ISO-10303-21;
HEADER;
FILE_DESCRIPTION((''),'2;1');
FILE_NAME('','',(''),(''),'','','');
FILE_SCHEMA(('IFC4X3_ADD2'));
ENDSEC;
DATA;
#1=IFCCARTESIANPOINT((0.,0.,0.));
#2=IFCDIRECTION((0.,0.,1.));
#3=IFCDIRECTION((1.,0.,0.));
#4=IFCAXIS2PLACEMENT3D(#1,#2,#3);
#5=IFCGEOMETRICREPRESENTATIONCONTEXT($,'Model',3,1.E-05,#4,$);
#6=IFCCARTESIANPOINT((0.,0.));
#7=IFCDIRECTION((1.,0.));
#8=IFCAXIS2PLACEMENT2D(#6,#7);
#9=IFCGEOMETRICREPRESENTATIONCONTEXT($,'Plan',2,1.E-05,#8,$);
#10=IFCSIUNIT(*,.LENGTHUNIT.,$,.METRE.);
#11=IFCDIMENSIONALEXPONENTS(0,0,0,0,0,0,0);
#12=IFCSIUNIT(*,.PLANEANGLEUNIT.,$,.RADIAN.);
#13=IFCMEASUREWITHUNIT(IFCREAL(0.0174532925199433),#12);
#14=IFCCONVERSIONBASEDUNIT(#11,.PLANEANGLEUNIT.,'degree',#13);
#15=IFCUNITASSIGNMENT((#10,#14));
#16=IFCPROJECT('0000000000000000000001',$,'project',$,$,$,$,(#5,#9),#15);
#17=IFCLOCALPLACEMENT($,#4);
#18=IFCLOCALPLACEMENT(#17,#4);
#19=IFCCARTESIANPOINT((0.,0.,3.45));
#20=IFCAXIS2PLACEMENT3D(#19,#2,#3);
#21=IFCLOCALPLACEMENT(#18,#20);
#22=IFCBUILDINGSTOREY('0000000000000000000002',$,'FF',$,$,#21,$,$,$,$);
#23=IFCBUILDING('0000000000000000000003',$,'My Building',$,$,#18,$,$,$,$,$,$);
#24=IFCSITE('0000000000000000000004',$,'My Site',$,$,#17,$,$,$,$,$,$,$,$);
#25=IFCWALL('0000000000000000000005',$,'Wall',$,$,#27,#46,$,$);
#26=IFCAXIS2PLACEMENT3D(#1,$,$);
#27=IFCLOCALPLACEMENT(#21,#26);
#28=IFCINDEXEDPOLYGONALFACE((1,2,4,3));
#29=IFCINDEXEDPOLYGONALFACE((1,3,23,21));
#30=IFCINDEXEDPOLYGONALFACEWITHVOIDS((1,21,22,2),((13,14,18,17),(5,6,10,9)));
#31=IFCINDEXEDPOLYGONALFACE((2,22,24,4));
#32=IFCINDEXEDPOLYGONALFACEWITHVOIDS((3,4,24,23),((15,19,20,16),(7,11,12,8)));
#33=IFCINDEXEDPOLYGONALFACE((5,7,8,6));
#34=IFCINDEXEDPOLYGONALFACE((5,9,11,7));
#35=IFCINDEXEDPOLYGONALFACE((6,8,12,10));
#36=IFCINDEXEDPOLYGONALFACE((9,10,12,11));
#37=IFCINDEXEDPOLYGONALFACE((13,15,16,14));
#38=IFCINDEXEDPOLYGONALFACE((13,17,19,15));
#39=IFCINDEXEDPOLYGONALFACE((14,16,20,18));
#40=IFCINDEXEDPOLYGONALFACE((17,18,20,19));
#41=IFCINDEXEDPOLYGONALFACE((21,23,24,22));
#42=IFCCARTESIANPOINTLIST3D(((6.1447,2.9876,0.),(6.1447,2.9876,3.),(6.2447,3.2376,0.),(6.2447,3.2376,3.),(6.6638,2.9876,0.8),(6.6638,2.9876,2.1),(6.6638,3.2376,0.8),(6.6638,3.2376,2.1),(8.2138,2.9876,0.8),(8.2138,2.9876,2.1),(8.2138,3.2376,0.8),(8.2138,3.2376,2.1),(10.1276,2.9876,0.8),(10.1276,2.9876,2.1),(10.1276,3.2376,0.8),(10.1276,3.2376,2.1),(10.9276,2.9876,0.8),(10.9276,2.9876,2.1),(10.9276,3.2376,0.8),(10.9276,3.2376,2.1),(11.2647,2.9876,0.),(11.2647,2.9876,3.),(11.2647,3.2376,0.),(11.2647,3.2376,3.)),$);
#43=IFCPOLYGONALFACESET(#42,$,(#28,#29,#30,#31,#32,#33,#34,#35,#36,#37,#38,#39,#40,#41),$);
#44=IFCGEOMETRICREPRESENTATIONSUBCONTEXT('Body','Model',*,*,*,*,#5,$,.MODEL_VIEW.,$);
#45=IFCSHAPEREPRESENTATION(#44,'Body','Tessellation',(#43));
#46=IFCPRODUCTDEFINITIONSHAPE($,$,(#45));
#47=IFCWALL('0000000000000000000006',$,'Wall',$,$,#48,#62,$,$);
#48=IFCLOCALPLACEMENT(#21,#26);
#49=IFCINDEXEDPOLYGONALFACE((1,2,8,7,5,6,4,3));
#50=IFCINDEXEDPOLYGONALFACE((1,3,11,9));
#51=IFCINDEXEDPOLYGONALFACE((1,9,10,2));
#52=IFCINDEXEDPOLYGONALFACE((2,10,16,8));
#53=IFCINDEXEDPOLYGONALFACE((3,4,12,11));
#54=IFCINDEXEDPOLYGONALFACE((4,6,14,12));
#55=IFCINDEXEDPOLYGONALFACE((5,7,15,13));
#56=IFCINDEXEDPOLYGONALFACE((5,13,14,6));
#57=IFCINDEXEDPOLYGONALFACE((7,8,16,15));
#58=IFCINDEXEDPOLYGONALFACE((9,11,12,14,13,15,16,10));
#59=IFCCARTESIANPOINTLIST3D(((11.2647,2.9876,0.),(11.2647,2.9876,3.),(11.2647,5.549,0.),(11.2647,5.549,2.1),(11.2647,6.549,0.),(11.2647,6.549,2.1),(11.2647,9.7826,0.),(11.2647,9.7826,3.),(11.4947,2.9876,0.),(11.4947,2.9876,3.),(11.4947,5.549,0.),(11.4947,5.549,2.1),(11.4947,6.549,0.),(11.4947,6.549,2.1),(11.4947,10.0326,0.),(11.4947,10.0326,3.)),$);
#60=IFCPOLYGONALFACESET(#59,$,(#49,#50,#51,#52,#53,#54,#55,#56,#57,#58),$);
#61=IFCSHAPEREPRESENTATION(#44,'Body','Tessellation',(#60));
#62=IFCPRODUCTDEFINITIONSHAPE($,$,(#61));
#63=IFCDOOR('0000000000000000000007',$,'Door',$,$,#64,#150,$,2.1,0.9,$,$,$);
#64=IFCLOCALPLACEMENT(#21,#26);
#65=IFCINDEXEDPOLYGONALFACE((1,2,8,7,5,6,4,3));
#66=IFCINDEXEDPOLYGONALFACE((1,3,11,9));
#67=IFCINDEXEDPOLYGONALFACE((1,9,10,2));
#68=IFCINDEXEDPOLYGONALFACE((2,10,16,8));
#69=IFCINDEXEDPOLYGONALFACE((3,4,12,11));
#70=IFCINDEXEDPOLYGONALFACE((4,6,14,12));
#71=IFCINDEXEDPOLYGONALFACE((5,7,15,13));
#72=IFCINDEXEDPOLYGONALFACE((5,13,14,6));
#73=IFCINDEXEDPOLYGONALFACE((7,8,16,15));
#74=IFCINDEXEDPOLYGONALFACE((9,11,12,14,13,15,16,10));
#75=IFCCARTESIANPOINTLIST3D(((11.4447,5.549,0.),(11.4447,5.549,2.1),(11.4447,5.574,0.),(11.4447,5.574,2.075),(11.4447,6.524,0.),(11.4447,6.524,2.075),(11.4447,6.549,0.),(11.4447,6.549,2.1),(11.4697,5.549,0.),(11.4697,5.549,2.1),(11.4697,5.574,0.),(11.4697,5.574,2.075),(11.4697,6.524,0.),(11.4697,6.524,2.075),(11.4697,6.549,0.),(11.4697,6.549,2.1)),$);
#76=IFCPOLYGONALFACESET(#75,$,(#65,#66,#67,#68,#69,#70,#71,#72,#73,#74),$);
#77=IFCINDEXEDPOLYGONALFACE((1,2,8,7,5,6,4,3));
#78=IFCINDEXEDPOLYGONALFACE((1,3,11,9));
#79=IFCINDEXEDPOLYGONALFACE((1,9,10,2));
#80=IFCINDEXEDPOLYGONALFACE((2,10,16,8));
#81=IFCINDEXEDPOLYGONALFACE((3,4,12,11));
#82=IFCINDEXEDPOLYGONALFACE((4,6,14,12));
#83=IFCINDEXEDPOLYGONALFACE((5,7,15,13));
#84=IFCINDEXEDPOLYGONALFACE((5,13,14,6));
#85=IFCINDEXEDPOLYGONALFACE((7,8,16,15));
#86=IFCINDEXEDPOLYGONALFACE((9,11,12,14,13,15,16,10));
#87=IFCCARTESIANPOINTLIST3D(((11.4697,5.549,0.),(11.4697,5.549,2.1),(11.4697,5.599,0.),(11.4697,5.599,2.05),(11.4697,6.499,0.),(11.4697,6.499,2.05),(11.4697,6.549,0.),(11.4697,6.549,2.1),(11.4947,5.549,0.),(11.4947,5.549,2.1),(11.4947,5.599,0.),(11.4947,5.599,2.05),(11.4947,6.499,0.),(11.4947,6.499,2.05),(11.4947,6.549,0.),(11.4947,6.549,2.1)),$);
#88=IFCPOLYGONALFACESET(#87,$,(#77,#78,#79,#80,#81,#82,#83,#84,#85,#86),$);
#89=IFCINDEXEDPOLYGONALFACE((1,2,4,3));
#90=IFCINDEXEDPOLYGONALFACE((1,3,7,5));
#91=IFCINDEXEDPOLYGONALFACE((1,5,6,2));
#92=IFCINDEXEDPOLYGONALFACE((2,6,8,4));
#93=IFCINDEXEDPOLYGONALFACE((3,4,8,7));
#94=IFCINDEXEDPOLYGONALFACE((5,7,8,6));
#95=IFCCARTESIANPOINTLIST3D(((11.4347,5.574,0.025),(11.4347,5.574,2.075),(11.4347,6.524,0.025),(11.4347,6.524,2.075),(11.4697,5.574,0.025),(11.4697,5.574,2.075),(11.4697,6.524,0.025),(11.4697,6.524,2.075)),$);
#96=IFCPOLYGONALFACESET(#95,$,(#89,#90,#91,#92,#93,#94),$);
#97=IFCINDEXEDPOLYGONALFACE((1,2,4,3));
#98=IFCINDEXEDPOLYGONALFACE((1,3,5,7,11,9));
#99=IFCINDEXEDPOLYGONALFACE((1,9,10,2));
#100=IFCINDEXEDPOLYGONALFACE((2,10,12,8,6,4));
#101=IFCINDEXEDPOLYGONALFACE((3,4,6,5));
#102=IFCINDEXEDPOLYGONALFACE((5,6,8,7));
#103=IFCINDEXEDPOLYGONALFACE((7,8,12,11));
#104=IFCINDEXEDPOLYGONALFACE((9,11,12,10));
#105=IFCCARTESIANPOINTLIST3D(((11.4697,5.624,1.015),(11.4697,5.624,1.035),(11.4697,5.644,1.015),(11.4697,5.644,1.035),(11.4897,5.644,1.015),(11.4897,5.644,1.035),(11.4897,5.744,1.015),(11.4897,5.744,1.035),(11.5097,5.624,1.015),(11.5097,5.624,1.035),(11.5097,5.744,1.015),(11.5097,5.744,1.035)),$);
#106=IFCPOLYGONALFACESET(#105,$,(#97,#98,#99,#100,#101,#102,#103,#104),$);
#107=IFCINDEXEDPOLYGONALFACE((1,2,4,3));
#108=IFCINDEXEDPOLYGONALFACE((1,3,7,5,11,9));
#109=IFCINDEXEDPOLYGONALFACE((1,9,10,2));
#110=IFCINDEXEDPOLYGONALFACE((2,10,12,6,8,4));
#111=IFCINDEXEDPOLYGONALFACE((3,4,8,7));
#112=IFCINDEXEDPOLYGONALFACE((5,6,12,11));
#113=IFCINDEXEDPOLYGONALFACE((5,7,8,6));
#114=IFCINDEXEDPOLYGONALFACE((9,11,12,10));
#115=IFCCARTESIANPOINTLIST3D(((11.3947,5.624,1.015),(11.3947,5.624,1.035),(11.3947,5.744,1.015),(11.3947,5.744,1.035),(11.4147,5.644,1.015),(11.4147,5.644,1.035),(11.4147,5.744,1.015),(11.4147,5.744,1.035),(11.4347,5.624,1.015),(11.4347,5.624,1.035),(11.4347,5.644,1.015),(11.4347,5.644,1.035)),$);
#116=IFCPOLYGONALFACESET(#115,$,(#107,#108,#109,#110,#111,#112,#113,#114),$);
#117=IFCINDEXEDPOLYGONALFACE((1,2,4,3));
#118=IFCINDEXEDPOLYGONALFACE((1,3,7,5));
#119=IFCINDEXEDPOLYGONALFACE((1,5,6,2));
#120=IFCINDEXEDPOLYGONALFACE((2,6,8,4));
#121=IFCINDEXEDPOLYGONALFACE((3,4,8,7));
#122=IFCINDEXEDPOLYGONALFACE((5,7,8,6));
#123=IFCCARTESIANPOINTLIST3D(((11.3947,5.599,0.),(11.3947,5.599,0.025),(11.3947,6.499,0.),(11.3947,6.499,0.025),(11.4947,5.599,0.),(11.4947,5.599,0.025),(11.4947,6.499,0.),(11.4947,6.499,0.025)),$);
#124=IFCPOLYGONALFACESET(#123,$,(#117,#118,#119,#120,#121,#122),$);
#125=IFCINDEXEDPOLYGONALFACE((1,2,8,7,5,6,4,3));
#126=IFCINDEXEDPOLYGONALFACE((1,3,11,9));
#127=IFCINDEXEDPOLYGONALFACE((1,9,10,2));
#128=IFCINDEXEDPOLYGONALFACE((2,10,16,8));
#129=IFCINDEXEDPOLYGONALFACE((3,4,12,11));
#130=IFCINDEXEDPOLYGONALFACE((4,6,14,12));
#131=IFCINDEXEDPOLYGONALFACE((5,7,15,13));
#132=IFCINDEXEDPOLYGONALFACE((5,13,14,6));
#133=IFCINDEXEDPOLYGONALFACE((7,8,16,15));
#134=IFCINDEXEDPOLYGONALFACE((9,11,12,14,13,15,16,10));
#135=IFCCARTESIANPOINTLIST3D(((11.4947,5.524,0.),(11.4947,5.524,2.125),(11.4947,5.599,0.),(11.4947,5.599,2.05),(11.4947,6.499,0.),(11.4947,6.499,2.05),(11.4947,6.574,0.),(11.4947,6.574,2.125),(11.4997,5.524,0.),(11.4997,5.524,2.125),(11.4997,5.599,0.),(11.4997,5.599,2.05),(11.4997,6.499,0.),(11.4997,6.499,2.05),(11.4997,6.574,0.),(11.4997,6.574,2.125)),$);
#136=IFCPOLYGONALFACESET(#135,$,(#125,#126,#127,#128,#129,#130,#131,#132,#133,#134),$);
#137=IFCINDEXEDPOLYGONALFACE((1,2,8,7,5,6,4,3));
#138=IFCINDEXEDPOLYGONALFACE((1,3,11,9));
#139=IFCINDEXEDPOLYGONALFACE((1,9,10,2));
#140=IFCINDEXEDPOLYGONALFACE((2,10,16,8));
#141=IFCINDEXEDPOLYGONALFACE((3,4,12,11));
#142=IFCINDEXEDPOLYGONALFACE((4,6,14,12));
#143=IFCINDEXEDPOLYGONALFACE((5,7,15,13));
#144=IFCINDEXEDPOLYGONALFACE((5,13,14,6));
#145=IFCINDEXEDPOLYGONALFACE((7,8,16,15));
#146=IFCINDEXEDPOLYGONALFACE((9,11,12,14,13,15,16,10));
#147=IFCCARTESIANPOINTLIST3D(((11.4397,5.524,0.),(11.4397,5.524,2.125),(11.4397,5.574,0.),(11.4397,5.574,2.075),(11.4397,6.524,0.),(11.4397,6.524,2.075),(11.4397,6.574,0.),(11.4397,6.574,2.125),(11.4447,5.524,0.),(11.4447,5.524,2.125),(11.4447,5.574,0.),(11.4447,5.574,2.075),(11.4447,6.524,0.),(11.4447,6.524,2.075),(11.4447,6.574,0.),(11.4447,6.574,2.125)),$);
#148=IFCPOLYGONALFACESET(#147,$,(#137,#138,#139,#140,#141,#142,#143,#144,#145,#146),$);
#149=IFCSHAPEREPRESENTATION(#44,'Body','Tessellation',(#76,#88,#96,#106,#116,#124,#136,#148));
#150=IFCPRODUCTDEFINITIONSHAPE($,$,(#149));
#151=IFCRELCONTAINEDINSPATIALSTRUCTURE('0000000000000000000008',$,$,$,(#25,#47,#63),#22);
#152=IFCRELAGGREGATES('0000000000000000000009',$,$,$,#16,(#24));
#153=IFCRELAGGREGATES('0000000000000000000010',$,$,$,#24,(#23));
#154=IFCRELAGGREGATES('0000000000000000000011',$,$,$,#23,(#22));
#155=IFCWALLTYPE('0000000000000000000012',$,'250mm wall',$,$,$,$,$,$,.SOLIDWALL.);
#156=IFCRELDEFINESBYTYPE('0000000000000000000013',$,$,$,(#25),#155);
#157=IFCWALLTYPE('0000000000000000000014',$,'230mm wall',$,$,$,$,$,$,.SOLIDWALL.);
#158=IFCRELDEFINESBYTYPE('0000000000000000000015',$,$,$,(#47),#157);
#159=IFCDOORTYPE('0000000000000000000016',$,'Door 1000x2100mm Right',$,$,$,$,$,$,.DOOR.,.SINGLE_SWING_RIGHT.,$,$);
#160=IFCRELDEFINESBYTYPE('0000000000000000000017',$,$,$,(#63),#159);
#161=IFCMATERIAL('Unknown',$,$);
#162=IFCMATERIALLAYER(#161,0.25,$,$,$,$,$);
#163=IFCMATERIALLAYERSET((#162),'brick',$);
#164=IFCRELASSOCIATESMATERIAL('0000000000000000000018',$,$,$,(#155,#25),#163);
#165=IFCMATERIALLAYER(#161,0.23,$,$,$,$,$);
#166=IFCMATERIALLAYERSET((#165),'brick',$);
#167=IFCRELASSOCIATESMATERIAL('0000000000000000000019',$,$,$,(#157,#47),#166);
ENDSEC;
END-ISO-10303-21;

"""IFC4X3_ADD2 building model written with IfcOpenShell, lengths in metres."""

from ifc_helpers import new_model, entity, si_unit, converted_unit, frame, origin_with_axes, origin_2d_with_axis, place, context, subcontext, project, spatial, line, indexed_curve, outline, extrude, shape, source, transform, mapped, material, layer, layer_set, layer_usage, type_object, type_shapes, element, fill, save


model = new_model("IFC4X3_ADD2")

# Units and contexts
model_context = context("Model", 3, precision=1e-05, world=origin_with_axes())
plan_context = context("Plan", 2, precision=1e-05, world=origin_2d_with_axis())
body_context_1 = subcontext(model_context, "Body", "Model", "MODEL_VIEW")
body_context_2 = subcontext(plan_context, "Body", "Plan", "PLAN_VIEW")
ifc_project = project(units=[si_unit("LENGTHUNIT", "METRE"), converted_unit("PLANEANGLEUNIT", "degree", entity("IfcReal", 0.0174532925199433), si_unit("PLANEANGLEUNIT", "RADIAN"), dimensions=[0, 0, 0, 0, 0, 0, 0])], contexts=[model_context, plan_context])

# Site, building, storey
site_placement = place(None, origin_with_axes())
site = spatial("IfcSite", under=ifc_project, at=site_placement, Name="My Site")
building_placement = place(site_placement, origin_with_axes())
building = spatial("IfcBuilding", under=site, at=building_placement, Name="My Building")
storey_placement = place(building_placement, frame((0.0, 0.0, 3.45), z_axis=(0.0, 0.0, 1.0), x_axis=(1.0, 0.0, 0.0)))
storey = spatial("IfcBuildingStorey", under=building, at=storey_placement, Name="FF")

# Wall, openings
ifc_material = material(Name="Unknown")
ifc_layer_1 = layer(ifc_material, 0.25)
ifc_layer_set_1 = layer_set([ifc_layer_1], Name="brick")
ifc_layer_usage_1 = layer_usage(ifc_layer_set_1, "AXIS2", "POSITIVE", 0.0)
wall_type_1 = type_object("IfcWallType", Name="250mm wall", PredefinedType="SOLIDWALL", material=ifc_layer_set_1)
wall_1_placement = place(storey_placement, frame((6.2447, 2.9876, 0.0), z_axis=(0.0, 0.0, 1.0), x_axis=(1.0, 0.0, 0.0)))
wall_1 = element("IfcWall", 1, at=wall_1_placement, inside=storey, type_object=wall_type_1, material=ifc_layer_usage_1, Name="Wall", context=body_context_1, shape_type="SweptSolid", body=[
    extrude(outline(indexed_curve([(-0.1, 0.0), (0.0, 0.25), (5.02, 0.25), (5.02, 0.0)], segments=[line(1, 2, 3, 4, 1)])), origin_with_axes(), (0.0, 0.0, 1.0), 3.0),
])
shared_shape_1 = source(origin_with_axes(), body_context_1, "Body", "SweptSolid", [
    extrude(outline(indexed_curve([(0.0, 0.0), (1.55, 0.0), (1.55, 1.3), (0.0, 1.3)], segments=[line(1, 2, 3, 4, 1)])), frame((-0.775, -0.6, 0.0), z_axis=(0.0, -1.0, 0.0), x_axis=(1.0, 0.0, 0.0)), (0.0, 0.0, -1.0), 1.2),
])
opening_1_placement = place(wall_1_placement, frame((1.1942, 0.0, 0.8), z_axis=(0.0, 0.0, 1.0), x_axis=(1.0, 0.0, 0.0)))
element("IfcOpeningElement", 2, at=opening_1_placement, cuts=wall_1, PredefinedType="OPENING", context=body_context_1, shape_type="MappedRepresentation", body=[
    mapped(shared_shape_1, transform((0.0, 0.0, 0.0), x_axis=(1.0, 0.0, 0.0), y_axis=(0.0, 1.0, 0.0), z_axis=(0.0, 0.0, 1.0), scale=1.0)),
])
shared_shape_2 = source(origin_with_axes(), body_context_1, "Body", "SweptSolid", [
    extrude(outline(indexed_curve([(0.0, 0.0), (0.8, 0.0), (0.8, 1.3), (0.0, 1.3)], segments=[line(1, 2, 3, 4, 1)])), frame((-0.4, -0.6, 0.0), z_axis=(0.0, -1.0, 0.0), x_axis=(1.0, 0.0, 0.0)), (0.0, 0.0, -1.0), 1.2),
])
opening_2_placement = place(wall_1_placement, frame((4.283, 0.0, 0.8), z_axis=(0.0, 0.0, 1.0), x_axis=(1.0, 0.0, 0.0)))
element("IfcOpeningElement", 3, at=opening_2_placement, cuts=wall_1, PredefinedType="OPENING", context=body_context_1, shape_type="MappedRepresentation", body=[
    mapped(shared_shape_2, transform((0.0, 0.0, 0.0), x_axis=(1.0, 0.0, 0.0), y_axis=(0.0, 1.0, 0.0), z_axis=(0.0, 0.0, 1.0), scale=1.0)),
])

# Wall, opening, door
ifc_layer_2 = layer(ifc_material, 0.23)
ifc_layer_set_2 = layer_set([ifc_layer_2], Name="brick")
ifc_layer_usage_2 = layer_usage(ifc_layer_set_2, "AXIS2", "POSITIVE", 0.0)
wall_type_2 = type_object("IfcWallType", Name="230mm wall", PredefinedType="SOLIDWALL", material=ifc_layer_set_2)
wall_2_placement = place(storey_placement, frame((11.4947, 2.9876, 0.0), z_axis=(0.0, 0.0, 1.0), x_axis=(0.0, 1.0, 0.0)))
wall_2 = element("IfcWall", 4, at=wall_2_placement, inside=storey, type_object=wall_type_2, material=ifc_layer_usage_2, Name="Wall", context=body_context_1, shape_type="SweptSolid", body=[
    extrude(outline(indexed_curve([(0.0, 0.0), (0.0, 0.23), (6.795, 0.23), (7.045, 0.0)], segments=[line(1, 2, 3, 4, 1)])), origin_with_axes(), (0.0, 0.0, 1.0), 3.0),
])
shared_shape_3 = source(origin_with_axes(), body_context_1, "Body", "SolidModel", [
    extrude(outline(indexed_curve([(0.0, 0.0), (1.0, 0.0), (1.0, 2.1), (0.0, 2.1)], segments=[line(1, 2, 3, 4, 1)])), frame((0.0, -0.6, 0.0), z_axis=(0.0, -1.0, 0.0), x_axis=(1.0, 0.0, 0.0)), (0.0, 0.0, -1.0), 1.2),
])
opening_3_placement = place(wall_2_placement, frame((2.5614, 0.0, 0.0), z_axis=(0.0, 0.0, 1.0), x_axis=(1.0, 0.0, 0.0)))
opening_3 = element("IfcOpeningElement", 5, at=opening_3_placement, cuts=wall_2, PredefinedType="OPENING", context=body_context_1, shape_type="MappedRepresentation", body=[
    mapped(shared_shape_3, transform((0.0, 0.0, 0.0), x_axis=(1.0, 0.0, 0.0), y_axis=(0.0, 1.0, 0.0), z_axis=(0.0, 0.0, 1.0), scale=1.0)),
])
door_type_1 = type_object("IfcDoorType", Name="Door 1000x2100mm Right", OperationType="SINGLE_SWING_RIGHT", PredefinedType="DOOR")
shared_shape_4 = source(origin_with_axes(), body_context_1, "Body", "SweptSolid", [
    extrude(outline(indexed_curve([(0.0, 0.0), (0.0, 2.1), (1.0, 2.1), (1.0, 0.0), (0.975, 0.0), (0.975, 2.075), (0.025, 2.075), (0.025, 0.0)], segments=[line(1, 2, 3, 4, 5, 6, 7, 8, 1)])), frame((0.0, 0.025, 0.0), z_axis=(0.0, -1.0, 0.0), x_axis=(1.0, 0.0, 0.0)), (0.0, 0.0, -1.0), 0.025),
    extrude(outline(indexed_curve([(0.0, 0.0), (0.0, 2.1), (1.0, 2.1), (1.0, 0.0), (0.95, 0.0), (0.95, 2.05), (0.05, 2.05), (0.05, 0.0)], segments=[line(1, 2, 3, 4, 5, 6, 7, 8, 1)])), frame((0.0, 0.0, 0.0), z_axis=(0.0, -1.0, 0.0), x_axis=(1.0, 0.0, 0.0)), (0.0, 0.0, -1.0), 0.025),
    extrude(outline(indexed_curve([(0.0, 0.0), (0.95, 0.0), (0.95, 0.035), (0.0, 0.035)], segments=[line(1, 2, 3, 4, 1)])), frame((0.025, 0.025, 0.025), z_axis=(0.0, 0.0, 1.0), x_axis=(1.0, 0.0, 0.0)), (0.0, 0.0, 1.0), 2.05),
    extrude(outline(indexed_curve([(0.0, 0.0), (0.0, -0.04), (0.12, -0.04), (0.12, -0.02), (0.02, -0.02), (0.02, 0.0)], segments=[line(1, 2, 3, 4, 5, 6, 1)])), frame((0.075, 0.025, 1.015), z_axis=(0.0, 0.0, 1.0), x_axis=(1.0, 0.0, 0.0)), (0.0, 0.0, 1.0), 0.02),
    extrude(outline(indexed_curve([(0.0, 0.0), (0.0, 0.04), (0.12, 0.04), (0.12, 0.02), (0.02, 0.02), (0.02, 0.0)], segments=[line(1, 2, 3, 4, 5, 6, 1)])), frame((0.075, 0.06, 1.015), z_axis=(0.0, 0.0, 1.0), x_axis=(1.0, 0.0, 0.0)), (0.0, 0.0, 1.0), 0.02),
    extrude(outline(indexed_curve([(0.0, 0.0), (0.9, 0.0), (0.9, 0.1), (0.0, 0.1)], segments=[line(1, 2, 3, 4, 1)])), frame((0.05, 0.0, 0.0), z_axis=(0.0, 0.0, 1.0), x_axis=(1.0, 0.0, 0.0)), (0.0, 0.0, 1.0), 0.025),
    extrude(outline(indexed_curve([(0.0, 0.0), (0.0, 2.125), (1.05, 2.125), (1.05, 0.0), (0.975, 0.0), (0.975, 2.05), (0.075, 2.05), (0.075, 0.0)], segments=[line(1, 2, 3, 4, 5, 6, 7, 8, 1)])), frame((-0.025, -0.005, 0.0), z_axis=(0.0, -1.0, 0.0), x_axis=(1.0, 0.0, 0.0)), (0.0, 0.0, -1.0), 0.005),
    extrude(outline(indexed_curve([(0.0, 0.0), (0.0, 2.125), (1.05, 2.125), (1.05, 0.0), (1.0, 0.0), (1.0, 2.075), (0.05, 2.075), (0.05, 0.0)], segments=[line(1, 2, 3, 4, 5, 6, 7, 8, 1)])), frame((-0.025, 0.05, 0.0), z_axis=(0.0, -1.0, 0.0), x_axis=(1.0, 0.0, 0.0)), (0.0, 0.0, -1.0), 0.005),
])
shared_shape_5 = source(origin_with_axes(), body_context_2, "Body", "Curve2D", [
    entity("IfcIndexedPolyCurve", entity("IfcCartesianPointList2D", [[0.0, 0.0], [0.0, 0.05], [0.025, 0.05], [0.025, 0.025], [0.05, 0.025], [0.05, 0.0]]), [entity("IfcLineIndex", [1, 2, 3, 4, 5, 6, 1])]),
    entity("IfcIndexedPolyCurve", entity("IfcCartesianPointList2D", [[1.0, 0.0], [1.0, 0.05], [0.975, 0.05], [0.975, 0.025], [0.95, 0.025], [0.95, 0.0]]), [entity("IfcLineIndex", [1, 2, 3, 4, 5, 6, 1])]),
    entity("IfcTrimmedCurve", entity("IfcEllipse", entity("IfcAxis2Placement2D", entity("IfcCartesianPoint", [0.94, 0.05]), entity("IfcDirection", [1.0, 0.0])), 0.915, 0.95), [entity("IfcCartesianPoint", [0.94, 1.0])], [entity("IfcCartesianPoint", [0.025, 0.05])], True, "CARTESIAN"),
    entity("IfcIndexedPolyCurve", entity("IfcCartesianPointList2D", [[0.975, 0.05], [0.94, 0.05], [0.94, 1.0], [0.975, 1.0]]), [entity("IfcLineIndex", [1, 2, 3, 4, 1])]),
])
type_shapes(door_type_1, [shared_shape_4, shared_shape_5])
door_1_placement = place(opening_3_placement, frame((0.0, 0.0, 0.0), z_axis=(0.0, 0.0, 1.0), x_axis=(1.0, 0.0, 0.0)))
door_1 = element("IfcDoor", 6, at=door_1_placement, inside=storey, type_object=door_type_1, Name="Door", OverallHeight=2.1, OverallWidth=0.9, shapes=[
    shape(body_context_1, "Body", "MappedRepresentation", [mapped(shared_shape_4, transform((0.0, 0.0, 0.0), x_axis=(1.0, 0.0, 0.0), y_axis=(0.0, 1.0, 0.0), z_axis=(0.0, 0.0, 1.0), scale=1.0))]),
    shape(body_context_2, "Body", "MappedRepresentation", [mapped(shared_shape_5, transform((0.0, 0.0, 0.0), x_axis=(1.0, 0.0, 0.0), y_axis=(0.0, 1.0, 0.0), z_axis=(0.0, 0.0, 1.0), scale=1.0))]),
])
fill(opening_3, door_1)

save(model, "model.ifc")
